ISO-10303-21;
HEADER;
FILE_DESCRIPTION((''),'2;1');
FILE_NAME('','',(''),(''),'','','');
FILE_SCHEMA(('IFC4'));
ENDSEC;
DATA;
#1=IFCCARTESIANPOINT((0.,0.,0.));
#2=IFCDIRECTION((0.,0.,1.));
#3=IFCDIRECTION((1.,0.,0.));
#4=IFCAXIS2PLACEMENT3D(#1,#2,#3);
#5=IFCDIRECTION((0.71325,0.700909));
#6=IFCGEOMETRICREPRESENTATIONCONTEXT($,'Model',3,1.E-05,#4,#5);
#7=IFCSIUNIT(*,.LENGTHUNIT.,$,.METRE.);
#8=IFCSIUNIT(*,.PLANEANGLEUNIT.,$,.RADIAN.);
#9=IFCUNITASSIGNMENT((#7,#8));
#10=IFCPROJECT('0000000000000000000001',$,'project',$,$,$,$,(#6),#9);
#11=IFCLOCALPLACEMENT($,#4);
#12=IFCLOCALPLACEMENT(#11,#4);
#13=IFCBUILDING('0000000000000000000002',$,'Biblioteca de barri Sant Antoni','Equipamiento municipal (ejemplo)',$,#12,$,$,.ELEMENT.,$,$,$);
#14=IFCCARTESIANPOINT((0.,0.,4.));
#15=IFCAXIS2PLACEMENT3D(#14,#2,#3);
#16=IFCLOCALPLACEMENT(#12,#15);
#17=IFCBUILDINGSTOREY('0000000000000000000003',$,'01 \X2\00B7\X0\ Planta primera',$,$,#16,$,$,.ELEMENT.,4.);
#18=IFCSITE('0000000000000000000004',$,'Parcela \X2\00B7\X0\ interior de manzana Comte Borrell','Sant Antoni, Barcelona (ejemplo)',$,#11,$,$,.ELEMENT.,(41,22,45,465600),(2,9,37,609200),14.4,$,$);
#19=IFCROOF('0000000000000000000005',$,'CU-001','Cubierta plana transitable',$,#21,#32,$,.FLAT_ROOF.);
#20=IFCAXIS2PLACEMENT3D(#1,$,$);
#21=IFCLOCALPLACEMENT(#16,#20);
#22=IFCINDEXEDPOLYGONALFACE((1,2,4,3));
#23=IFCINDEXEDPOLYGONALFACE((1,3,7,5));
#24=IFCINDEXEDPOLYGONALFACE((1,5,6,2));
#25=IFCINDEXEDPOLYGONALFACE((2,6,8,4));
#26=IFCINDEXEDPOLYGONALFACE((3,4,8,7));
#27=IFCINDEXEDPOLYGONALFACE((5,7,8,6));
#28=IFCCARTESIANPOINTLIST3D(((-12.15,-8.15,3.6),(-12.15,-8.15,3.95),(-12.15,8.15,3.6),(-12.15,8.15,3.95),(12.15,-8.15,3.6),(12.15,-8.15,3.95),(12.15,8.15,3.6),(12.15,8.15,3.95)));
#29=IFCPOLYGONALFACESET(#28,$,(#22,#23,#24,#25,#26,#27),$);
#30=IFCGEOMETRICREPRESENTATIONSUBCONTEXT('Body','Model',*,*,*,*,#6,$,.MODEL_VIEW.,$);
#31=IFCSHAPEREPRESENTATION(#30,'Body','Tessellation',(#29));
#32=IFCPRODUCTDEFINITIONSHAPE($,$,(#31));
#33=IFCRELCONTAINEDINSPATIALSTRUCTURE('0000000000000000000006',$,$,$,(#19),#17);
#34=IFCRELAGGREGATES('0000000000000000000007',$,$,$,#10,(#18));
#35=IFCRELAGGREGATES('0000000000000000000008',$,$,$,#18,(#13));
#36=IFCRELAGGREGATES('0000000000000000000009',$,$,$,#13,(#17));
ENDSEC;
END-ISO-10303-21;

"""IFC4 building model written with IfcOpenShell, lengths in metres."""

from ifc_helpers import new_model, si_unit, direction, frame, origin_with_axes, origin_2d, place, context, subcontext, project, spatial, rectangle, extrude, element, save


model = new_model("IFC4")

# Units and contexts
model_context = context("Model", 3, precision=1e-05, world=origin_with_axes(), true_north=direction((0.71325, 0.700909)))
body_context = subcontext(model_context, "Body", "Model", "MODEL_VIEW")
ifc_project = project(units=[si_unit("LENGTHUNIT", "METRE"), si_unit("PLANEANGLEUNIT", "RADIAN")], contexts=[model_context])

# Site, building, storey
site_placement = place(None, origin_with_axes())
site = spatial("IfcSite", under=ifc_project, at=site_placement, Name="Parcela · interior de manzana Comte Borrell", Description="Sant Antoni, Barcelona (ejemplo)", CompositionType="ELEMENT", RefLatitude=(41, 22, 45, 465600), RefLongitude=(2, 9, 37, 609200), RefElevation=14.4)
building_placement = place(site_placement, origin_with_axes())
building = spatial("IfcBuilding", under=site, at=building_placement, Name="Biblioteca de barri Sant Antoni", Description="Equipamiento municipal (ejemplo)", CompositionType="ELEMENT")
storey_placement = place(building_placement, frame((0.0, 0.0, 4.0), z_axis=(0.0, 0.0, 1.0), x_axis=(1.0, 0.0, 0.0)))
storey = spatial("IfcBuildingStorey", under=building, at=storey_placement, Name="01 · Planta primera", CompositionType="ELEMENT", Elevation=4.0)

# Roof
roof_placement = place(storey_placement, frame((0.0, 0.0, 3.6), z_axis=(0.0, 0.0, 1.0), x_axis=(1.0, 0.0, 0.0)))
element("IfcRoof", 1, at=roof_placement, inside=storey, Name="CU-001", Description="Cubierta plana transitable", PredefinedType="FLAT_ROOF", context=body_context, shape_type="SweptSolid", body=[
    extrude(rectangle(XDim=24.3, YDim=16.3, at=origin_2d()), origin_with_axes(), (0.0, 0.0, 1.0), 0.35),
])

save(model, "model.ifc")
